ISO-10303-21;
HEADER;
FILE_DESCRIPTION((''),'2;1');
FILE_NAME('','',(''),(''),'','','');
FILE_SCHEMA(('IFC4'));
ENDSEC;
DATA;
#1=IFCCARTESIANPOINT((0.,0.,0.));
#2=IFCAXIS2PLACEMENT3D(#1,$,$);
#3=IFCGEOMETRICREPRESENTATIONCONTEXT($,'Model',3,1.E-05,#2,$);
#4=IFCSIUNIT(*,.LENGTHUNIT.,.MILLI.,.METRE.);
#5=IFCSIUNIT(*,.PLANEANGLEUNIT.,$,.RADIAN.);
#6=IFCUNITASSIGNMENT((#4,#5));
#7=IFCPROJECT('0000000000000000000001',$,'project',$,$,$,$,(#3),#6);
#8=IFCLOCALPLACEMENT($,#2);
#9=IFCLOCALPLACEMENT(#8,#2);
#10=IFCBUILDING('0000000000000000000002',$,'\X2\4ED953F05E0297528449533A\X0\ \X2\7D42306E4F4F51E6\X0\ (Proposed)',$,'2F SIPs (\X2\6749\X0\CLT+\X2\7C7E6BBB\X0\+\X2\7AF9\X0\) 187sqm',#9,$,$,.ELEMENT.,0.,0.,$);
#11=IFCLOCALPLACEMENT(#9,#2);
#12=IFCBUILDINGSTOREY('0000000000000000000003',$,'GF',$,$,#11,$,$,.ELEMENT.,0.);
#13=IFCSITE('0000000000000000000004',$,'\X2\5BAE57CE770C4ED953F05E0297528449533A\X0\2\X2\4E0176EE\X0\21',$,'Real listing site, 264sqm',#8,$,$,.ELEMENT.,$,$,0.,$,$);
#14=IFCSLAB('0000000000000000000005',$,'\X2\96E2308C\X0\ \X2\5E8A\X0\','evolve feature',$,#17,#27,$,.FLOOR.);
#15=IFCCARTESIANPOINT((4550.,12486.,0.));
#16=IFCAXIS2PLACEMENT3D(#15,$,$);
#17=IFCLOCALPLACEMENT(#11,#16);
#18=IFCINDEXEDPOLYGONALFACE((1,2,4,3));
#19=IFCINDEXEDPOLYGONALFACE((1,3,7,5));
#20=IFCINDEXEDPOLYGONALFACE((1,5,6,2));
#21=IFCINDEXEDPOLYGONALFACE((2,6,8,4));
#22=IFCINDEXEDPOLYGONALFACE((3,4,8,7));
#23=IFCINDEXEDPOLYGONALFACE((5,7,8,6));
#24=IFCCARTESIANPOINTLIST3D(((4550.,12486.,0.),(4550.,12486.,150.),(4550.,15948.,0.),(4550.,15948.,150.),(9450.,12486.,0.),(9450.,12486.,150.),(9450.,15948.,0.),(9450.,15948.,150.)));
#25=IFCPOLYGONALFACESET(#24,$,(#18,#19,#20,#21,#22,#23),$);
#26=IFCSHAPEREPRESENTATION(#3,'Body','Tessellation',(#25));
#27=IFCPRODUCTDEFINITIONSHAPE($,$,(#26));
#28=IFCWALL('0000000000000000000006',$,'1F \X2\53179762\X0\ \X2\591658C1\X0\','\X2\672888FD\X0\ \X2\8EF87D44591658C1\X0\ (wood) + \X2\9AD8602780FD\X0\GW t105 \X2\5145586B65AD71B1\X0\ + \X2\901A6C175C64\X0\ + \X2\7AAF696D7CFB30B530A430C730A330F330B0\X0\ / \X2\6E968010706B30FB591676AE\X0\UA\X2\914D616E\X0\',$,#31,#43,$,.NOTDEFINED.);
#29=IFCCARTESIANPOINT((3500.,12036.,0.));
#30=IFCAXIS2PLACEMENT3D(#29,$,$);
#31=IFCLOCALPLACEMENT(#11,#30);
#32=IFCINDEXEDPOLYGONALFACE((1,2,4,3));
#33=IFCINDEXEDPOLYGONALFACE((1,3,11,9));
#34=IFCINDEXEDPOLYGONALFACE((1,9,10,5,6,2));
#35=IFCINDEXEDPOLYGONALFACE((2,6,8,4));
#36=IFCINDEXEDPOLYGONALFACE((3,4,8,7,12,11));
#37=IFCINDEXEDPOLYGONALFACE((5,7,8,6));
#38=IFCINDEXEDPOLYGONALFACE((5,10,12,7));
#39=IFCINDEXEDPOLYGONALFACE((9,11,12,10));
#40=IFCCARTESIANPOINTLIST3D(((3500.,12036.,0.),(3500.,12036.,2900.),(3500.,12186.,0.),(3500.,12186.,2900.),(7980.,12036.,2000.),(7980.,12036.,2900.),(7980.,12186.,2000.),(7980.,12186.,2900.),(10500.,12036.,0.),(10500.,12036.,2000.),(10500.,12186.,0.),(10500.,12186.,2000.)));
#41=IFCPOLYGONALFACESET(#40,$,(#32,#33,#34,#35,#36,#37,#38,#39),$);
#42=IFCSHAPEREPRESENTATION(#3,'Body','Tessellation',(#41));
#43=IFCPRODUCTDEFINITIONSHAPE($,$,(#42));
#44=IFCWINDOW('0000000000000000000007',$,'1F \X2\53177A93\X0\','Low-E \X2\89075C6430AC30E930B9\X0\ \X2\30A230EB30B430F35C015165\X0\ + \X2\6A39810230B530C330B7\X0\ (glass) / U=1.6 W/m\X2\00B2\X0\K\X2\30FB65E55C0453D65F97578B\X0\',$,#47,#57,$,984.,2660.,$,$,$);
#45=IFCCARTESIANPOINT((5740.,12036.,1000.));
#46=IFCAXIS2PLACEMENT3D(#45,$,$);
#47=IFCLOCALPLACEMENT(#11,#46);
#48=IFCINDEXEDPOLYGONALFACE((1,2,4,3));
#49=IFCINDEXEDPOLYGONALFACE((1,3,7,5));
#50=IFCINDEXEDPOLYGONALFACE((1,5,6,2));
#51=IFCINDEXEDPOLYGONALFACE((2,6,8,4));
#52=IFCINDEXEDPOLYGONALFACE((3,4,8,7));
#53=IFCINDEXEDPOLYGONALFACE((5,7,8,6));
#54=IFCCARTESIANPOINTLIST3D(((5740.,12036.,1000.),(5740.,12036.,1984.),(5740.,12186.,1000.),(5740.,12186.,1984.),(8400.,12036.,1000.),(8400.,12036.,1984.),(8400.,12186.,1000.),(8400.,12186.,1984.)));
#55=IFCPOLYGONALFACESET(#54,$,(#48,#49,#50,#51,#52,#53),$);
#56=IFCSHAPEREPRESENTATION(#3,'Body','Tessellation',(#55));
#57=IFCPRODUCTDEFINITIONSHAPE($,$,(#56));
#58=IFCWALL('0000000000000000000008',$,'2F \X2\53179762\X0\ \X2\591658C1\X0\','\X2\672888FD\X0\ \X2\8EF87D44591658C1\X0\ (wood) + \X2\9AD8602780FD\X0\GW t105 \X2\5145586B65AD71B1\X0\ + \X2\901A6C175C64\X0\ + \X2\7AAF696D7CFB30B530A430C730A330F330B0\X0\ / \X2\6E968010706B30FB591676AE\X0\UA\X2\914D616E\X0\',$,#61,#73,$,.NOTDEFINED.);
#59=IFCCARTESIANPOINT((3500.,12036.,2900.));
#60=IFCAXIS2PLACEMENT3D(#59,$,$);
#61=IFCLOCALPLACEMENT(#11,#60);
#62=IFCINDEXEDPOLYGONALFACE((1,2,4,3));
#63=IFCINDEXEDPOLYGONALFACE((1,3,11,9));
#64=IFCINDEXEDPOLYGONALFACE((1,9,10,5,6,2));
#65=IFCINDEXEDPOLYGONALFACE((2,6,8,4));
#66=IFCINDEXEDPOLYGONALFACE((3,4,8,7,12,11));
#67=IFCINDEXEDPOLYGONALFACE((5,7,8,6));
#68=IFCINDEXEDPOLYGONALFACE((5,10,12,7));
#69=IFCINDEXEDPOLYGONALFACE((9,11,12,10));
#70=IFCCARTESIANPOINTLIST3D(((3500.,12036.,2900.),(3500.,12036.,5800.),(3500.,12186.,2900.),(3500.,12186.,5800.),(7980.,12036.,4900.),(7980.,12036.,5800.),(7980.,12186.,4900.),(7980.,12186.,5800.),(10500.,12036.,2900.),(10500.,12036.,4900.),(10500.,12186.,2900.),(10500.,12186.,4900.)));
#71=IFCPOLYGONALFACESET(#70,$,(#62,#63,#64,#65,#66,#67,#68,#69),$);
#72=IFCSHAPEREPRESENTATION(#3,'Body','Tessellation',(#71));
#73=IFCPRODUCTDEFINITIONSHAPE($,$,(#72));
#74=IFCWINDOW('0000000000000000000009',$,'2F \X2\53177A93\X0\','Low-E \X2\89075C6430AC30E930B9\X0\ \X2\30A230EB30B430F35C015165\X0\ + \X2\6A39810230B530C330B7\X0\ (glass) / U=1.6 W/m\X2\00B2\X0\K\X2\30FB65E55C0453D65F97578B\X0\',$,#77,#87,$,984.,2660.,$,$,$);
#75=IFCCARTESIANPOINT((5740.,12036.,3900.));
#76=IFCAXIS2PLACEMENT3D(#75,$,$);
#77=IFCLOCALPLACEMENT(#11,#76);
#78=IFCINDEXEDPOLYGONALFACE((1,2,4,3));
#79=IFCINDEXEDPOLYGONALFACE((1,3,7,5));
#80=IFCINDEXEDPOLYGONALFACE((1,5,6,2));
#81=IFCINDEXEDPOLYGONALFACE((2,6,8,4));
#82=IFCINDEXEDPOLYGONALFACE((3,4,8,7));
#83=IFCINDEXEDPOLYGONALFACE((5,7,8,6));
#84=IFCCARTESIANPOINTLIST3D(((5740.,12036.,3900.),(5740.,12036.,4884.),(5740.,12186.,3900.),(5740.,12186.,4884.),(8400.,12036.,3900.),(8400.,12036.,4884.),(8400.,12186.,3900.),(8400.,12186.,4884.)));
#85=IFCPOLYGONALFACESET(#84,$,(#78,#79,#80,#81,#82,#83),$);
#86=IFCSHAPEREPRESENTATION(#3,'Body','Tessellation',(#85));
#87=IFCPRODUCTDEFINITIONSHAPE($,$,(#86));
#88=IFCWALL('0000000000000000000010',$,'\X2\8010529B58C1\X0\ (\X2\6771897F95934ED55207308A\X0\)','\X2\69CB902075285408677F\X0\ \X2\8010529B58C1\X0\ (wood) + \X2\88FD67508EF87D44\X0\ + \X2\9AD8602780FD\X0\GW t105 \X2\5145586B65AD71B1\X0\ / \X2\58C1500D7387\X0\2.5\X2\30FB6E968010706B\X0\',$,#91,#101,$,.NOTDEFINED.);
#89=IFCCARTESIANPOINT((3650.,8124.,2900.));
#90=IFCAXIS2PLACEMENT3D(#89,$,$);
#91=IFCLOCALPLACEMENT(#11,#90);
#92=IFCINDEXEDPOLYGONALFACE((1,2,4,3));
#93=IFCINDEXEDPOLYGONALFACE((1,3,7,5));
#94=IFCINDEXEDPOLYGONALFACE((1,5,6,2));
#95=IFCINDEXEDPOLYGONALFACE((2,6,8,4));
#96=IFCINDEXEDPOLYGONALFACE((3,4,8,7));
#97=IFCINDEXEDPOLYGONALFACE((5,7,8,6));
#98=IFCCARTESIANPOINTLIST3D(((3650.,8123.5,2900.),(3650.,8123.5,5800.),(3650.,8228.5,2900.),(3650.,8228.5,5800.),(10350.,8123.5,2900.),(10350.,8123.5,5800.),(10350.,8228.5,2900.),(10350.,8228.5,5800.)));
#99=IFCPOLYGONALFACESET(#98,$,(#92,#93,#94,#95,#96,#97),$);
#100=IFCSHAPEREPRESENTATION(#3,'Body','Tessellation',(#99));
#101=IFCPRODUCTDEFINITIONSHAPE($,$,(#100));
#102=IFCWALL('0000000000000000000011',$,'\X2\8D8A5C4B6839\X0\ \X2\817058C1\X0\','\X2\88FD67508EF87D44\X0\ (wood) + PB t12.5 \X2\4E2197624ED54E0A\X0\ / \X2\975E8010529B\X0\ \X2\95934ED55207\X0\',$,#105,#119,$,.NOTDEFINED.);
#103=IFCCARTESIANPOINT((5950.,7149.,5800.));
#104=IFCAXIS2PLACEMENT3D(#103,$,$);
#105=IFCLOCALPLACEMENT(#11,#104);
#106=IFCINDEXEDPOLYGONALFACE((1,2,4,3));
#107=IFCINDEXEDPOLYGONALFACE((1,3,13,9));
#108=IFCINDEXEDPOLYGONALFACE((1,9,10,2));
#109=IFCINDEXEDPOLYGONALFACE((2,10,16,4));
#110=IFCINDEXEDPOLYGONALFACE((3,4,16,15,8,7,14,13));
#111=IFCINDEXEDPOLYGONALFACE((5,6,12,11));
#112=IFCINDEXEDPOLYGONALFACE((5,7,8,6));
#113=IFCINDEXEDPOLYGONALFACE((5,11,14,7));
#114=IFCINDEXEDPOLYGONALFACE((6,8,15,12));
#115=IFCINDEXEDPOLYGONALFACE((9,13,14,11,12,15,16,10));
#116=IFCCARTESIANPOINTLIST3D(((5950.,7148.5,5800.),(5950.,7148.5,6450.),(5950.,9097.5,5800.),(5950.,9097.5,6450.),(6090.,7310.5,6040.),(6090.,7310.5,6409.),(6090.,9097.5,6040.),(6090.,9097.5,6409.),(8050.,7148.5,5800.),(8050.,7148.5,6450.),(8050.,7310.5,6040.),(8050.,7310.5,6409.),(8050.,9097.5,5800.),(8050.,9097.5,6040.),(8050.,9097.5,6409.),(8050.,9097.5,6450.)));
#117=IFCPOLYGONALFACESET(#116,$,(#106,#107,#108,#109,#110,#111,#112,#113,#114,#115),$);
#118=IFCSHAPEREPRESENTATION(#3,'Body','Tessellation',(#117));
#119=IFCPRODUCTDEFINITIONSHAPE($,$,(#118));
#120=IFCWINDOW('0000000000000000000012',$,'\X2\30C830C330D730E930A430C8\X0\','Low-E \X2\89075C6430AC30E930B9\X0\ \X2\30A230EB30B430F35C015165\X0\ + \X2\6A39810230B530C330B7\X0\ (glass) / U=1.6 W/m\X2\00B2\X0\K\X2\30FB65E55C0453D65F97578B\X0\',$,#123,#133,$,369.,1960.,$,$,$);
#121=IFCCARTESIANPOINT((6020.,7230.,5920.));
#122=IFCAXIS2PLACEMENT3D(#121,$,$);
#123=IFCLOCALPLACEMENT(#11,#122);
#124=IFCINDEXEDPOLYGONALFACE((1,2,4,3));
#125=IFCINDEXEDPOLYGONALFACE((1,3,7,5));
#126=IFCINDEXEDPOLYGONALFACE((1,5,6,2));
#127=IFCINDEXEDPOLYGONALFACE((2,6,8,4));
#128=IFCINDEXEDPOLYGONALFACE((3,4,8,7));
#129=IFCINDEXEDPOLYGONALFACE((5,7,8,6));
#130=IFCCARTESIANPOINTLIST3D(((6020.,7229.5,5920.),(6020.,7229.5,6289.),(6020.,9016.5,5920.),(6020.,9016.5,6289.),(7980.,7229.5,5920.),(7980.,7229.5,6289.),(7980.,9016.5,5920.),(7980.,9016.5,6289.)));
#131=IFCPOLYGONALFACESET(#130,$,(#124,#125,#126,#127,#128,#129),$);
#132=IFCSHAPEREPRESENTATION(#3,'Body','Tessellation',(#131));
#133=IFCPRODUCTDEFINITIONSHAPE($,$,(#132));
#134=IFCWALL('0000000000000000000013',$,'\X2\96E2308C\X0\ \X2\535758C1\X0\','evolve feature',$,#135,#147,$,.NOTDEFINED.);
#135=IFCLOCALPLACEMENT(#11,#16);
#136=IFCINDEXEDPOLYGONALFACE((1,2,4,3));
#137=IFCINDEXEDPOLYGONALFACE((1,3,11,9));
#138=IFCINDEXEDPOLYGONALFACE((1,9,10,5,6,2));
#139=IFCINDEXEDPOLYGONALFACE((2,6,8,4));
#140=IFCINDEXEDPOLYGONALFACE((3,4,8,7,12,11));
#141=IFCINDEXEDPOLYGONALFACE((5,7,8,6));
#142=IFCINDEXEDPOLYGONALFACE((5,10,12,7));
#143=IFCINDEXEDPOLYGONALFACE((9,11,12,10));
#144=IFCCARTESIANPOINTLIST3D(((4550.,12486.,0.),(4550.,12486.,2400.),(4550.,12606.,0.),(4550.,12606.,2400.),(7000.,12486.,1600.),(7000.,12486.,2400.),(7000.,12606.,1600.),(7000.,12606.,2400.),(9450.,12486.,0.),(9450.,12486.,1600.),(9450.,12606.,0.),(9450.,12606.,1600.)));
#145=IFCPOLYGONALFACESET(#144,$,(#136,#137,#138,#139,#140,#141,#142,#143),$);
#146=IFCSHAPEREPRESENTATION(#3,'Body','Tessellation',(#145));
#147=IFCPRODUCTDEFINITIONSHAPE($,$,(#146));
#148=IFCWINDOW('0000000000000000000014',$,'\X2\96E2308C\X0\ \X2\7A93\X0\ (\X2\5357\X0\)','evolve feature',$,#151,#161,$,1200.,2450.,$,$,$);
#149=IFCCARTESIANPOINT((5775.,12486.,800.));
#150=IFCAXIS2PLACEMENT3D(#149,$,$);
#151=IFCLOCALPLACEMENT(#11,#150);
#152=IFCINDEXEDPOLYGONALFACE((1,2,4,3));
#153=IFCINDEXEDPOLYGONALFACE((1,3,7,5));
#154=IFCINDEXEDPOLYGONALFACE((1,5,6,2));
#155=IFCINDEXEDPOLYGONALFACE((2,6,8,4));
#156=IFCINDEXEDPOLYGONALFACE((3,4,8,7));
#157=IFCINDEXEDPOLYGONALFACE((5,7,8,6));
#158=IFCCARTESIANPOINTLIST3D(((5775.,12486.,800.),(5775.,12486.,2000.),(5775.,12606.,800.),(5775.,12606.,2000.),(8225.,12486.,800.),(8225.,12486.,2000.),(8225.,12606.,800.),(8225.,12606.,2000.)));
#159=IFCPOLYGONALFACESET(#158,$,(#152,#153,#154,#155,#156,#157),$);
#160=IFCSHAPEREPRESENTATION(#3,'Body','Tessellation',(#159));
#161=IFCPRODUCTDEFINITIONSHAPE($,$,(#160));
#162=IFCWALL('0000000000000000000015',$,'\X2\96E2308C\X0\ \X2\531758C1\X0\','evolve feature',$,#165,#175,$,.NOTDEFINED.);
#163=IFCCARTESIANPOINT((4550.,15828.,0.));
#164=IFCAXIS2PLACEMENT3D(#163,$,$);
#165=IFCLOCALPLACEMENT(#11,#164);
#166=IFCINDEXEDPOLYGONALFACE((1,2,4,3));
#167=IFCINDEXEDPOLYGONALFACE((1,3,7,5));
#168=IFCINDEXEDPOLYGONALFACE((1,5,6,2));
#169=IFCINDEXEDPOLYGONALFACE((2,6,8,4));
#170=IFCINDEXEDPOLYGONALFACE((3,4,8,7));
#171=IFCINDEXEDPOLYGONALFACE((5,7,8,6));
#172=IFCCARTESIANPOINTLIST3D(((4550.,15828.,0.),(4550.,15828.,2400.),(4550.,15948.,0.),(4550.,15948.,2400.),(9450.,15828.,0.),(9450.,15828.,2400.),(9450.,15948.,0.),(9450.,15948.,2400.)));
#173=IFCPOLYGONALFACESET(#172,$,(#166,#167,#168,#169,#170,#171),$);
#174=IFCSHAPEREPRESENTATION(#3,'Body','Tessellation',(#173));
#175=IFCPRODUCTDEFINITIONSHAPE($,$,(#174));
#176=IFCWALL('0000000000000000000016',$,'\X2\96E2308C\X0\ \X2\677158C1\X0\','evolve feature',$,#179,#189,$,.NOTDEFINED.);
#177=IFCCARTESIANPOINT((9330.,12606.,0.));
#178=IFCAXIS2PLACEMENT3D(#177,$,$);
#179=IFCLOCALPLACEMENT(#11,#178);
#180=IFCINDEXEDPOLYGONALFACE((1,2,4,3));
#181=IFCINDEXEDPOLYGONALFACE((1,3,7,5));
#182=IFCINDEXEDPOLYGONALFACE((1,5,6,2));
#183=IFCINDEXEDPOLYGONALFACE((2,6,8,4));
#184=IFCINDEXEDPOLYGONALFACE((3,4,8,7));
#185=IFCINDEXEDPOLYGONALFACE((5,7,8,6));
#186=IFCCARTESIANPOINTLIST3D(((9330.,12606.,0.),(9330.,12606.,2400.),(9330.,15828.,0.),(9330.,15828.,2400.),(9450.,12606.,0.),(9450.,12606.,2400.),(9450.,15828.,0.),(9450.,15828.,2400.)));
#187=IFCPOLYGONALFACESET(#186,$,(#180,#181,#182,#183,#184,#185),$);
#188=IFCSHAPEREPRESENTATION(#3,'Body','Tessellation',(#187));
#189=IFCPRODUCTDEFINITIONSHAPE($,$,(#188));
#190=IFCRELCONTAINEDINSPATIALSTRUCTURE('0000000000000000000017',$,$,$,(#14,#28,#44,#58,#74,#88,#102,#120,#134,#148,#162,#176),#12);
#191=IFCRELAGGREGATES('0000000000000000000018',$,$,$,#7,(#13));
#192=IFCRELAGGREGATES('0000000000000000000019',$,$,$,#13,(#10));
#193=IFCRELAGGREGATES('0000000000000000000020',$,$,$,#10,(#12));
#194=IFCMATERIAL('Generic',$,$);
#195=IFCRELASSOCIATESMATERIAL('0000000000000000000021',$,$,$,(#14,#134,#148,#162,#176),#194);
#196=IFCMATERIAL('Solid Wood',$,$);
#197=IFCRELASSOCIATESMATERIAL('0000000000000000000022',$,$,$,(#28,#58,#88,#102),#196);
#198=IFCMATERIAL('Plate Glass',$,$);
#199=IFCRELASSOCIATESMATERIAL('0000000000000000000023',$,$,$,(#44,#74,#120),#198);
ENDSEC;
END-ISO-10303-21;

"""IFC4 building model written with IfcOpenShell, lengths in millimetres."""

from ifc_helpers import new_model, si_unit, frame, frame_2d, origin, place, context, project, spatial, rectangle, extrude, material, element, fill, save


model = new_model("IFC4")

# Units and contexts
model_context = context("Model", 3, precision=1e-05, world=origin())
ifc_project = project(units=[si_unit("LENGTHUNIT", "METRE", prefix="MILLI"), si_unit("PLANEANGLEUNIT", "RADIAN")], contexts=[model_context])

# Site, building, storey
site_placement = place(None, origin())
site = spatial("IfcSite", under=ifc_project, at=site_placement, Name="宮城県仙台市青葉区2丁目21", ObjectType="Real listing site, 264sqm", CompositionType="ELEMENT", RefElevation=0.0)
building_placement = place(site_placement, origin())
building = spatial("IfcBuilding", under=site, at=building_placement, Name="仙台市青葉区 終の住処 (Proposed)", ObjectType="2F SIPs (杉CLT+籾殻+竹) 187sqm", CompositionType="ELEMENT", ElevationOfRefHeight=0.0, ElevationOfTerrain=0.0)
storey_placement = place(building_placement, origin())
storey = spatial("IfcBuildingStorey", under=building, at=storey_placement, Name="GF", CompositionType="ELEMENT", Elevation=0.0)

# Slab
ifc_material_1 = material(Name="Generic")
slab_placement = place(storey_placement, frame((4550.0, 12486.0, 0.0)))
element("IfcSlab", 1, at=slab_placement, inside=storey, material=ifc_material_1, Name="離れ 床", Description="evolve feature", PredefinedType="FLOOR", context=model_context, shape_type="SweptSolid", body=[
    extrude(rectangle(XDim=4900.0, YDim=3462.0, at=frame_2d((2450.0, 1731.0))), frame((4550.0, 12486.0, 0.0)), (0.0, 0.0, 1.0), 150.0),
])

# Wall, opening, window
ifc_material_2 = material(Name="Solid Wood")
wall_1_placement = place(storey_placement, frame((3500.0, 12036.0, 0.0)))
wall_1 = element("IfcWall", 2, at=wall_1_placement, inside=storey, material=ifc_material_2, Name="1F 北面 外壁", Description="木製 軸組外壁 (wood) + 高性能GW t105 充填断熱 + 通気層 + 窯業系サイディング / 準耐火・外皮UA配慮", PredefinedType="NOTDEFINED", context=model_context, shape_type="SweptSolid", body=[
    extrude(rectangle(XDim=7000.0, YDim=150.0, at=frame_2d((3500.0, 75.0))), frame((3500.0, 12036.0, 0.0)), (0.0, 0.0, 1.0), 2900.0),
])
opening_1_placement = place(storey_placement, frame((5740.0, 12036.0, 1000.0)))
opening_1 = element("IfcOpeningElement", 3, at=opening_1_placement, cuts=wall_1, PredefinedType="NOTDEFINED", context=model_context, shape_type="SweptSolid", body=[
    extrude(rectangle(XDim=2660.0, YDim=150.0, at=frame_2d((1330.0, 75.0))), frame((5740.0, 12036.0, 1000.0)), (0.0, 0.0, 1.0), 984.0),
])
ifc_material_3 = material(Name="Plate Glass")
window_1_placement = place(storey_placement, frame((5740.0, 12036.0, 1000.0)))
window_1 = element("IfcWindow", 4, at=window_1_placement, inside=storey, material=ifc_material_3, Name="1F 北窓", Description="Low-E 複層ガラス アルゴン封入 + 樹脂サッシ (glass) / U=1.6 W/m²K・日射取得型", OverallHeight=984.0, OverallWidth=2660.0, context=model_context, shape_type="SweptSolid", body=[
    extrude(rectangle(XDim=2660.0, YDim=150.0, at=frame_2d((1330.0, 75.0))), frame((5740.0, 12036.0, 1000.0)), (0.0, 0.0, 1.0), 984.0),
])
fill(opening_1, window_1)

# Wall, opening, window
wall_2_placement = place(storey_placement, frame((3500.0, 12036.0, 2900.0)))
wall_2 = element("IfcWall", 5, at=wall_2_placement, inside=storey, material=ifc_material_2, Name="2F 北面 外壁", Description="木製 軸組外壁 (wood) + 高性能GW t105 充填断熱 + 通気層 + 窯業系サイディング / 準耐火・外皮UA配慮", PredefinedType="NOTDEFINED", context=model_context, shape_type="SweptSolid", body=[
    extrude(rectangle(XDim=7000.0, YDim=150.0, at=frame_2d((3500.0, 75.0))), frame((3500.0, 12036.0, 2900.0)), (0.0, 0.0, 1.0), 2900.0),
])
opening_2_placement = place(storey_placement, frame((5740.0, 12036.0, 3900.0)))
opening_2 = element("IfcOpeningElement", 6, at=opening_2_placement, cuts=wall_2, PredefinedType="NOTDEFINED", context=model_context, shape_type="SweptSolid", body=[
    extrude(rectangle(XDim=2660.0, YDim=150.0, at=frame_2d((1330.0, 75.0))), frame((5740.0, 12036.0, 3900.0)), (0.0, 0.0, 1.0), 984.0),
])
window_2_placement = place(storey_placement, frame((5740.0, 12036.0, 3900.0)))
window_2 = element("IfcWindow", 7, at=window_2_placement, inside=storey, material=ifc_material_3, Name="2F 北窓", Description="Low-E 複層ガラス アルゴン封入 + 樹脂サッシ (glass) / U=1.6 W/m²K・日射取得型", OverallHeight=984.0, OverallWidth=2660.0, context=model_context, shape_type="SweptSolid", body=[
    extrude(rectangle(XDim=2660.0, YDim=150.0, at=frame_2d((1330.0, 75.0))), frame((5740.0, 12036.0, 3900.0)), (0.0, 0.0, 1.0), 984.0),
])
fill(opening_2, window_2)

# Wall
wall_3_placement = place(storey_placement, frame((3650.0, 8124.0, 2900.0)))
element("IfcWall", 8, at=wall_3_placement, inside=storey, material=ifc_material_2, Name="耐力壁 (東西間仕切り)", Description="構造用合板 耐力壁 (wood) + 製材軸組 + 高性能GW t105 充填断熱 / 壁倍率2.5・準耐火", PredefinedType="NOTDEFINED", context=model_context, shape_type="SweptSolid", body=[
    extrude(rectangle(XDim=6700.0, YDim=105.0, at=frame_2d((3350.0, 52.0))), frame((3650.0, 8124.0, 2900.0)), (0.0, 0.0, 1.0), 2900.0),
])

# Walls, openings, windows
wall_4_placement = place(storey_placement, frame((5950.0, 7149.0, 5800.0)))
wall_4 = element("IfcWall", 9, at=wall_4_placement, inside=storey, material=ifc_material_2, Name="越屋根 腰壁", Description="製材軸組 (wood) + PB t12.5 両面仕上 / 非耐力 間仕切", PredefinedType="NOTDEFINED", context=model_context, shape_type="SweptSolid", body=[
    extrude(rectangle(XDim=2100.0, YDim=1949.0, at=frame_2d((1050.0, 974.0))), frame((5950.0, 7149.0, 5800.0)), (0.0, 0.0, 1.0), 650.0),
])
opening_3_placement = place(storey_placement, frame((6020.0, 7230.0, 5920.0)))
opening_3 = element("IfcOpeningElement", 10, at=opening_3_placement, cuts=wall_4, PredefinedType="NOTDEFINED", context=model_context, shape_type="SweptSolid", body=[
    extrude(rectangle(XDim=1960.0, YDim=1787.0, at=frame_2d((980.0, 893.0))), frame((6020.0, 7230.0, 5920.0)), (0.0, 0.0, 1.0), 369.0),
])
window_3_placement = place(storey_placement, frame((6020.0, 7230.0, 5920.0)))
window_3 = element("IfcWindow", 11, at=window_3_placement, inside=storey, material=ifc_material_3, Name="トップライト", Description="Low-E 複層ガラス アルゴン封入 + 樹脂サッシ (glass) / U=1.6 W/m²K・日射取得型", OverallHeight=369.0, OverallWidth=1960.0, context=model_context, shape_type="SweptSolid", body=[
    extrude(rectangle(XDim=1960.0, YDim=1787.0, at=frame_2d((980.0, 893.0))), frame((6020.0, 7230.0, 5920.0)), (0.0, 0.0, 1.0), 369.0),
])
fill(opening_3, window_3)
wall_5_placement = place(storey_placement, frame((4550.0, 12486.0, 0.0)))
wall_5 = element("IfcWall", 12, at=wall_5_placement, inside=storey, material=ifc_material_1, Name="離れ 南壁", Description="evolve feature", PredefinedType="NOTDEFINED", context=model_context, shape_type="SweptSolid", body=[
    extrude(rectangle(XDim=4900.0, YDim=120.0, at=frame_2d((2450.0, 60.0))), frame((4550.0, 12486.0, 0.0)), (0.0, 0.0, 1.0), 2400.0),
])
opening_4_placement = place(storey_placement, frame((5775.0, 12486.0, 800.0)))
opening_4 = element("IfcOpeningElement", 13, at=opening_4_placement, cuts=wall_5, PredefinedType="NOTDEFINED", context=model_context, shape_type="SweptSolid", body=[
    extrude(rectangle(XDim=2450.0, YDim=120.0, at=frame_2d((1225.0, 60.0))), frame((5775.0, 12486.0, 800.0)), (0.0, 0.0, 1.0), 1200.0),
])
window_4_placement = place(storey_placement, frame((5775.0, 12486.0, 800.0)))
window_4 = element("IfcWindow", 14, at=window_4_placement, inside=storey, material=ifc_material_1, Name="離れ 窓 (南)", Description="evolve feature", OverallHeight=1200.0, OverallWidth=2450.0, context=model_context, shape_type="SweptSolid", body=[
    extrude(rectangle(XDim=2450.0, YDim=120.0, at=frame_2d((1225.0, 60.0))), frame((5775.0, 12486.0, 800.0)), (0.0, 0.0, 1.0), 1200.0),
])
fill(opening_4, window_4)

# Walls
wall_6_placement = place(storey_placement, frame((4550.0, 15828.0, 0.0)))
element("IfcWall", 15, at=wall_6_placement, inside=storey, material=ifc_material_1, Name="離れ 北壁", Description="evolve feature", PredefinedType="NOTDEFINED", context=model_context, shape_type="SweptSolid", body=[
    extrude(rectangle(XDim=4900.0, YDim=120.0, at=frame_2d((2450.0, 60.0))), frame((4550.0, 15828.0, 0.0)), (0.0, 0.0, 1.0), 2400.0),
])
wall_7_placement = place(storey_placement, frame((9330.0, 12606.0, 0.0)))
element("IfcWall", 16, at=wall_7_placement, inside=storey, material=ifc_material_1, Name="離れ 東壁", Description="evolve feature", PredefinedType="NOTDEFINED", context=model_context, shape_type="SweptSolid", body=[
    extrude(rectangle(XDim=120.0, YDim=3222.0, at=frame_2d((60.0, 1611.0))), frame((9330.0, 12606.0, 0.0)), (0.0, 0.0, 1.0), 2400.0),
])

save(model, "model.ifc")
